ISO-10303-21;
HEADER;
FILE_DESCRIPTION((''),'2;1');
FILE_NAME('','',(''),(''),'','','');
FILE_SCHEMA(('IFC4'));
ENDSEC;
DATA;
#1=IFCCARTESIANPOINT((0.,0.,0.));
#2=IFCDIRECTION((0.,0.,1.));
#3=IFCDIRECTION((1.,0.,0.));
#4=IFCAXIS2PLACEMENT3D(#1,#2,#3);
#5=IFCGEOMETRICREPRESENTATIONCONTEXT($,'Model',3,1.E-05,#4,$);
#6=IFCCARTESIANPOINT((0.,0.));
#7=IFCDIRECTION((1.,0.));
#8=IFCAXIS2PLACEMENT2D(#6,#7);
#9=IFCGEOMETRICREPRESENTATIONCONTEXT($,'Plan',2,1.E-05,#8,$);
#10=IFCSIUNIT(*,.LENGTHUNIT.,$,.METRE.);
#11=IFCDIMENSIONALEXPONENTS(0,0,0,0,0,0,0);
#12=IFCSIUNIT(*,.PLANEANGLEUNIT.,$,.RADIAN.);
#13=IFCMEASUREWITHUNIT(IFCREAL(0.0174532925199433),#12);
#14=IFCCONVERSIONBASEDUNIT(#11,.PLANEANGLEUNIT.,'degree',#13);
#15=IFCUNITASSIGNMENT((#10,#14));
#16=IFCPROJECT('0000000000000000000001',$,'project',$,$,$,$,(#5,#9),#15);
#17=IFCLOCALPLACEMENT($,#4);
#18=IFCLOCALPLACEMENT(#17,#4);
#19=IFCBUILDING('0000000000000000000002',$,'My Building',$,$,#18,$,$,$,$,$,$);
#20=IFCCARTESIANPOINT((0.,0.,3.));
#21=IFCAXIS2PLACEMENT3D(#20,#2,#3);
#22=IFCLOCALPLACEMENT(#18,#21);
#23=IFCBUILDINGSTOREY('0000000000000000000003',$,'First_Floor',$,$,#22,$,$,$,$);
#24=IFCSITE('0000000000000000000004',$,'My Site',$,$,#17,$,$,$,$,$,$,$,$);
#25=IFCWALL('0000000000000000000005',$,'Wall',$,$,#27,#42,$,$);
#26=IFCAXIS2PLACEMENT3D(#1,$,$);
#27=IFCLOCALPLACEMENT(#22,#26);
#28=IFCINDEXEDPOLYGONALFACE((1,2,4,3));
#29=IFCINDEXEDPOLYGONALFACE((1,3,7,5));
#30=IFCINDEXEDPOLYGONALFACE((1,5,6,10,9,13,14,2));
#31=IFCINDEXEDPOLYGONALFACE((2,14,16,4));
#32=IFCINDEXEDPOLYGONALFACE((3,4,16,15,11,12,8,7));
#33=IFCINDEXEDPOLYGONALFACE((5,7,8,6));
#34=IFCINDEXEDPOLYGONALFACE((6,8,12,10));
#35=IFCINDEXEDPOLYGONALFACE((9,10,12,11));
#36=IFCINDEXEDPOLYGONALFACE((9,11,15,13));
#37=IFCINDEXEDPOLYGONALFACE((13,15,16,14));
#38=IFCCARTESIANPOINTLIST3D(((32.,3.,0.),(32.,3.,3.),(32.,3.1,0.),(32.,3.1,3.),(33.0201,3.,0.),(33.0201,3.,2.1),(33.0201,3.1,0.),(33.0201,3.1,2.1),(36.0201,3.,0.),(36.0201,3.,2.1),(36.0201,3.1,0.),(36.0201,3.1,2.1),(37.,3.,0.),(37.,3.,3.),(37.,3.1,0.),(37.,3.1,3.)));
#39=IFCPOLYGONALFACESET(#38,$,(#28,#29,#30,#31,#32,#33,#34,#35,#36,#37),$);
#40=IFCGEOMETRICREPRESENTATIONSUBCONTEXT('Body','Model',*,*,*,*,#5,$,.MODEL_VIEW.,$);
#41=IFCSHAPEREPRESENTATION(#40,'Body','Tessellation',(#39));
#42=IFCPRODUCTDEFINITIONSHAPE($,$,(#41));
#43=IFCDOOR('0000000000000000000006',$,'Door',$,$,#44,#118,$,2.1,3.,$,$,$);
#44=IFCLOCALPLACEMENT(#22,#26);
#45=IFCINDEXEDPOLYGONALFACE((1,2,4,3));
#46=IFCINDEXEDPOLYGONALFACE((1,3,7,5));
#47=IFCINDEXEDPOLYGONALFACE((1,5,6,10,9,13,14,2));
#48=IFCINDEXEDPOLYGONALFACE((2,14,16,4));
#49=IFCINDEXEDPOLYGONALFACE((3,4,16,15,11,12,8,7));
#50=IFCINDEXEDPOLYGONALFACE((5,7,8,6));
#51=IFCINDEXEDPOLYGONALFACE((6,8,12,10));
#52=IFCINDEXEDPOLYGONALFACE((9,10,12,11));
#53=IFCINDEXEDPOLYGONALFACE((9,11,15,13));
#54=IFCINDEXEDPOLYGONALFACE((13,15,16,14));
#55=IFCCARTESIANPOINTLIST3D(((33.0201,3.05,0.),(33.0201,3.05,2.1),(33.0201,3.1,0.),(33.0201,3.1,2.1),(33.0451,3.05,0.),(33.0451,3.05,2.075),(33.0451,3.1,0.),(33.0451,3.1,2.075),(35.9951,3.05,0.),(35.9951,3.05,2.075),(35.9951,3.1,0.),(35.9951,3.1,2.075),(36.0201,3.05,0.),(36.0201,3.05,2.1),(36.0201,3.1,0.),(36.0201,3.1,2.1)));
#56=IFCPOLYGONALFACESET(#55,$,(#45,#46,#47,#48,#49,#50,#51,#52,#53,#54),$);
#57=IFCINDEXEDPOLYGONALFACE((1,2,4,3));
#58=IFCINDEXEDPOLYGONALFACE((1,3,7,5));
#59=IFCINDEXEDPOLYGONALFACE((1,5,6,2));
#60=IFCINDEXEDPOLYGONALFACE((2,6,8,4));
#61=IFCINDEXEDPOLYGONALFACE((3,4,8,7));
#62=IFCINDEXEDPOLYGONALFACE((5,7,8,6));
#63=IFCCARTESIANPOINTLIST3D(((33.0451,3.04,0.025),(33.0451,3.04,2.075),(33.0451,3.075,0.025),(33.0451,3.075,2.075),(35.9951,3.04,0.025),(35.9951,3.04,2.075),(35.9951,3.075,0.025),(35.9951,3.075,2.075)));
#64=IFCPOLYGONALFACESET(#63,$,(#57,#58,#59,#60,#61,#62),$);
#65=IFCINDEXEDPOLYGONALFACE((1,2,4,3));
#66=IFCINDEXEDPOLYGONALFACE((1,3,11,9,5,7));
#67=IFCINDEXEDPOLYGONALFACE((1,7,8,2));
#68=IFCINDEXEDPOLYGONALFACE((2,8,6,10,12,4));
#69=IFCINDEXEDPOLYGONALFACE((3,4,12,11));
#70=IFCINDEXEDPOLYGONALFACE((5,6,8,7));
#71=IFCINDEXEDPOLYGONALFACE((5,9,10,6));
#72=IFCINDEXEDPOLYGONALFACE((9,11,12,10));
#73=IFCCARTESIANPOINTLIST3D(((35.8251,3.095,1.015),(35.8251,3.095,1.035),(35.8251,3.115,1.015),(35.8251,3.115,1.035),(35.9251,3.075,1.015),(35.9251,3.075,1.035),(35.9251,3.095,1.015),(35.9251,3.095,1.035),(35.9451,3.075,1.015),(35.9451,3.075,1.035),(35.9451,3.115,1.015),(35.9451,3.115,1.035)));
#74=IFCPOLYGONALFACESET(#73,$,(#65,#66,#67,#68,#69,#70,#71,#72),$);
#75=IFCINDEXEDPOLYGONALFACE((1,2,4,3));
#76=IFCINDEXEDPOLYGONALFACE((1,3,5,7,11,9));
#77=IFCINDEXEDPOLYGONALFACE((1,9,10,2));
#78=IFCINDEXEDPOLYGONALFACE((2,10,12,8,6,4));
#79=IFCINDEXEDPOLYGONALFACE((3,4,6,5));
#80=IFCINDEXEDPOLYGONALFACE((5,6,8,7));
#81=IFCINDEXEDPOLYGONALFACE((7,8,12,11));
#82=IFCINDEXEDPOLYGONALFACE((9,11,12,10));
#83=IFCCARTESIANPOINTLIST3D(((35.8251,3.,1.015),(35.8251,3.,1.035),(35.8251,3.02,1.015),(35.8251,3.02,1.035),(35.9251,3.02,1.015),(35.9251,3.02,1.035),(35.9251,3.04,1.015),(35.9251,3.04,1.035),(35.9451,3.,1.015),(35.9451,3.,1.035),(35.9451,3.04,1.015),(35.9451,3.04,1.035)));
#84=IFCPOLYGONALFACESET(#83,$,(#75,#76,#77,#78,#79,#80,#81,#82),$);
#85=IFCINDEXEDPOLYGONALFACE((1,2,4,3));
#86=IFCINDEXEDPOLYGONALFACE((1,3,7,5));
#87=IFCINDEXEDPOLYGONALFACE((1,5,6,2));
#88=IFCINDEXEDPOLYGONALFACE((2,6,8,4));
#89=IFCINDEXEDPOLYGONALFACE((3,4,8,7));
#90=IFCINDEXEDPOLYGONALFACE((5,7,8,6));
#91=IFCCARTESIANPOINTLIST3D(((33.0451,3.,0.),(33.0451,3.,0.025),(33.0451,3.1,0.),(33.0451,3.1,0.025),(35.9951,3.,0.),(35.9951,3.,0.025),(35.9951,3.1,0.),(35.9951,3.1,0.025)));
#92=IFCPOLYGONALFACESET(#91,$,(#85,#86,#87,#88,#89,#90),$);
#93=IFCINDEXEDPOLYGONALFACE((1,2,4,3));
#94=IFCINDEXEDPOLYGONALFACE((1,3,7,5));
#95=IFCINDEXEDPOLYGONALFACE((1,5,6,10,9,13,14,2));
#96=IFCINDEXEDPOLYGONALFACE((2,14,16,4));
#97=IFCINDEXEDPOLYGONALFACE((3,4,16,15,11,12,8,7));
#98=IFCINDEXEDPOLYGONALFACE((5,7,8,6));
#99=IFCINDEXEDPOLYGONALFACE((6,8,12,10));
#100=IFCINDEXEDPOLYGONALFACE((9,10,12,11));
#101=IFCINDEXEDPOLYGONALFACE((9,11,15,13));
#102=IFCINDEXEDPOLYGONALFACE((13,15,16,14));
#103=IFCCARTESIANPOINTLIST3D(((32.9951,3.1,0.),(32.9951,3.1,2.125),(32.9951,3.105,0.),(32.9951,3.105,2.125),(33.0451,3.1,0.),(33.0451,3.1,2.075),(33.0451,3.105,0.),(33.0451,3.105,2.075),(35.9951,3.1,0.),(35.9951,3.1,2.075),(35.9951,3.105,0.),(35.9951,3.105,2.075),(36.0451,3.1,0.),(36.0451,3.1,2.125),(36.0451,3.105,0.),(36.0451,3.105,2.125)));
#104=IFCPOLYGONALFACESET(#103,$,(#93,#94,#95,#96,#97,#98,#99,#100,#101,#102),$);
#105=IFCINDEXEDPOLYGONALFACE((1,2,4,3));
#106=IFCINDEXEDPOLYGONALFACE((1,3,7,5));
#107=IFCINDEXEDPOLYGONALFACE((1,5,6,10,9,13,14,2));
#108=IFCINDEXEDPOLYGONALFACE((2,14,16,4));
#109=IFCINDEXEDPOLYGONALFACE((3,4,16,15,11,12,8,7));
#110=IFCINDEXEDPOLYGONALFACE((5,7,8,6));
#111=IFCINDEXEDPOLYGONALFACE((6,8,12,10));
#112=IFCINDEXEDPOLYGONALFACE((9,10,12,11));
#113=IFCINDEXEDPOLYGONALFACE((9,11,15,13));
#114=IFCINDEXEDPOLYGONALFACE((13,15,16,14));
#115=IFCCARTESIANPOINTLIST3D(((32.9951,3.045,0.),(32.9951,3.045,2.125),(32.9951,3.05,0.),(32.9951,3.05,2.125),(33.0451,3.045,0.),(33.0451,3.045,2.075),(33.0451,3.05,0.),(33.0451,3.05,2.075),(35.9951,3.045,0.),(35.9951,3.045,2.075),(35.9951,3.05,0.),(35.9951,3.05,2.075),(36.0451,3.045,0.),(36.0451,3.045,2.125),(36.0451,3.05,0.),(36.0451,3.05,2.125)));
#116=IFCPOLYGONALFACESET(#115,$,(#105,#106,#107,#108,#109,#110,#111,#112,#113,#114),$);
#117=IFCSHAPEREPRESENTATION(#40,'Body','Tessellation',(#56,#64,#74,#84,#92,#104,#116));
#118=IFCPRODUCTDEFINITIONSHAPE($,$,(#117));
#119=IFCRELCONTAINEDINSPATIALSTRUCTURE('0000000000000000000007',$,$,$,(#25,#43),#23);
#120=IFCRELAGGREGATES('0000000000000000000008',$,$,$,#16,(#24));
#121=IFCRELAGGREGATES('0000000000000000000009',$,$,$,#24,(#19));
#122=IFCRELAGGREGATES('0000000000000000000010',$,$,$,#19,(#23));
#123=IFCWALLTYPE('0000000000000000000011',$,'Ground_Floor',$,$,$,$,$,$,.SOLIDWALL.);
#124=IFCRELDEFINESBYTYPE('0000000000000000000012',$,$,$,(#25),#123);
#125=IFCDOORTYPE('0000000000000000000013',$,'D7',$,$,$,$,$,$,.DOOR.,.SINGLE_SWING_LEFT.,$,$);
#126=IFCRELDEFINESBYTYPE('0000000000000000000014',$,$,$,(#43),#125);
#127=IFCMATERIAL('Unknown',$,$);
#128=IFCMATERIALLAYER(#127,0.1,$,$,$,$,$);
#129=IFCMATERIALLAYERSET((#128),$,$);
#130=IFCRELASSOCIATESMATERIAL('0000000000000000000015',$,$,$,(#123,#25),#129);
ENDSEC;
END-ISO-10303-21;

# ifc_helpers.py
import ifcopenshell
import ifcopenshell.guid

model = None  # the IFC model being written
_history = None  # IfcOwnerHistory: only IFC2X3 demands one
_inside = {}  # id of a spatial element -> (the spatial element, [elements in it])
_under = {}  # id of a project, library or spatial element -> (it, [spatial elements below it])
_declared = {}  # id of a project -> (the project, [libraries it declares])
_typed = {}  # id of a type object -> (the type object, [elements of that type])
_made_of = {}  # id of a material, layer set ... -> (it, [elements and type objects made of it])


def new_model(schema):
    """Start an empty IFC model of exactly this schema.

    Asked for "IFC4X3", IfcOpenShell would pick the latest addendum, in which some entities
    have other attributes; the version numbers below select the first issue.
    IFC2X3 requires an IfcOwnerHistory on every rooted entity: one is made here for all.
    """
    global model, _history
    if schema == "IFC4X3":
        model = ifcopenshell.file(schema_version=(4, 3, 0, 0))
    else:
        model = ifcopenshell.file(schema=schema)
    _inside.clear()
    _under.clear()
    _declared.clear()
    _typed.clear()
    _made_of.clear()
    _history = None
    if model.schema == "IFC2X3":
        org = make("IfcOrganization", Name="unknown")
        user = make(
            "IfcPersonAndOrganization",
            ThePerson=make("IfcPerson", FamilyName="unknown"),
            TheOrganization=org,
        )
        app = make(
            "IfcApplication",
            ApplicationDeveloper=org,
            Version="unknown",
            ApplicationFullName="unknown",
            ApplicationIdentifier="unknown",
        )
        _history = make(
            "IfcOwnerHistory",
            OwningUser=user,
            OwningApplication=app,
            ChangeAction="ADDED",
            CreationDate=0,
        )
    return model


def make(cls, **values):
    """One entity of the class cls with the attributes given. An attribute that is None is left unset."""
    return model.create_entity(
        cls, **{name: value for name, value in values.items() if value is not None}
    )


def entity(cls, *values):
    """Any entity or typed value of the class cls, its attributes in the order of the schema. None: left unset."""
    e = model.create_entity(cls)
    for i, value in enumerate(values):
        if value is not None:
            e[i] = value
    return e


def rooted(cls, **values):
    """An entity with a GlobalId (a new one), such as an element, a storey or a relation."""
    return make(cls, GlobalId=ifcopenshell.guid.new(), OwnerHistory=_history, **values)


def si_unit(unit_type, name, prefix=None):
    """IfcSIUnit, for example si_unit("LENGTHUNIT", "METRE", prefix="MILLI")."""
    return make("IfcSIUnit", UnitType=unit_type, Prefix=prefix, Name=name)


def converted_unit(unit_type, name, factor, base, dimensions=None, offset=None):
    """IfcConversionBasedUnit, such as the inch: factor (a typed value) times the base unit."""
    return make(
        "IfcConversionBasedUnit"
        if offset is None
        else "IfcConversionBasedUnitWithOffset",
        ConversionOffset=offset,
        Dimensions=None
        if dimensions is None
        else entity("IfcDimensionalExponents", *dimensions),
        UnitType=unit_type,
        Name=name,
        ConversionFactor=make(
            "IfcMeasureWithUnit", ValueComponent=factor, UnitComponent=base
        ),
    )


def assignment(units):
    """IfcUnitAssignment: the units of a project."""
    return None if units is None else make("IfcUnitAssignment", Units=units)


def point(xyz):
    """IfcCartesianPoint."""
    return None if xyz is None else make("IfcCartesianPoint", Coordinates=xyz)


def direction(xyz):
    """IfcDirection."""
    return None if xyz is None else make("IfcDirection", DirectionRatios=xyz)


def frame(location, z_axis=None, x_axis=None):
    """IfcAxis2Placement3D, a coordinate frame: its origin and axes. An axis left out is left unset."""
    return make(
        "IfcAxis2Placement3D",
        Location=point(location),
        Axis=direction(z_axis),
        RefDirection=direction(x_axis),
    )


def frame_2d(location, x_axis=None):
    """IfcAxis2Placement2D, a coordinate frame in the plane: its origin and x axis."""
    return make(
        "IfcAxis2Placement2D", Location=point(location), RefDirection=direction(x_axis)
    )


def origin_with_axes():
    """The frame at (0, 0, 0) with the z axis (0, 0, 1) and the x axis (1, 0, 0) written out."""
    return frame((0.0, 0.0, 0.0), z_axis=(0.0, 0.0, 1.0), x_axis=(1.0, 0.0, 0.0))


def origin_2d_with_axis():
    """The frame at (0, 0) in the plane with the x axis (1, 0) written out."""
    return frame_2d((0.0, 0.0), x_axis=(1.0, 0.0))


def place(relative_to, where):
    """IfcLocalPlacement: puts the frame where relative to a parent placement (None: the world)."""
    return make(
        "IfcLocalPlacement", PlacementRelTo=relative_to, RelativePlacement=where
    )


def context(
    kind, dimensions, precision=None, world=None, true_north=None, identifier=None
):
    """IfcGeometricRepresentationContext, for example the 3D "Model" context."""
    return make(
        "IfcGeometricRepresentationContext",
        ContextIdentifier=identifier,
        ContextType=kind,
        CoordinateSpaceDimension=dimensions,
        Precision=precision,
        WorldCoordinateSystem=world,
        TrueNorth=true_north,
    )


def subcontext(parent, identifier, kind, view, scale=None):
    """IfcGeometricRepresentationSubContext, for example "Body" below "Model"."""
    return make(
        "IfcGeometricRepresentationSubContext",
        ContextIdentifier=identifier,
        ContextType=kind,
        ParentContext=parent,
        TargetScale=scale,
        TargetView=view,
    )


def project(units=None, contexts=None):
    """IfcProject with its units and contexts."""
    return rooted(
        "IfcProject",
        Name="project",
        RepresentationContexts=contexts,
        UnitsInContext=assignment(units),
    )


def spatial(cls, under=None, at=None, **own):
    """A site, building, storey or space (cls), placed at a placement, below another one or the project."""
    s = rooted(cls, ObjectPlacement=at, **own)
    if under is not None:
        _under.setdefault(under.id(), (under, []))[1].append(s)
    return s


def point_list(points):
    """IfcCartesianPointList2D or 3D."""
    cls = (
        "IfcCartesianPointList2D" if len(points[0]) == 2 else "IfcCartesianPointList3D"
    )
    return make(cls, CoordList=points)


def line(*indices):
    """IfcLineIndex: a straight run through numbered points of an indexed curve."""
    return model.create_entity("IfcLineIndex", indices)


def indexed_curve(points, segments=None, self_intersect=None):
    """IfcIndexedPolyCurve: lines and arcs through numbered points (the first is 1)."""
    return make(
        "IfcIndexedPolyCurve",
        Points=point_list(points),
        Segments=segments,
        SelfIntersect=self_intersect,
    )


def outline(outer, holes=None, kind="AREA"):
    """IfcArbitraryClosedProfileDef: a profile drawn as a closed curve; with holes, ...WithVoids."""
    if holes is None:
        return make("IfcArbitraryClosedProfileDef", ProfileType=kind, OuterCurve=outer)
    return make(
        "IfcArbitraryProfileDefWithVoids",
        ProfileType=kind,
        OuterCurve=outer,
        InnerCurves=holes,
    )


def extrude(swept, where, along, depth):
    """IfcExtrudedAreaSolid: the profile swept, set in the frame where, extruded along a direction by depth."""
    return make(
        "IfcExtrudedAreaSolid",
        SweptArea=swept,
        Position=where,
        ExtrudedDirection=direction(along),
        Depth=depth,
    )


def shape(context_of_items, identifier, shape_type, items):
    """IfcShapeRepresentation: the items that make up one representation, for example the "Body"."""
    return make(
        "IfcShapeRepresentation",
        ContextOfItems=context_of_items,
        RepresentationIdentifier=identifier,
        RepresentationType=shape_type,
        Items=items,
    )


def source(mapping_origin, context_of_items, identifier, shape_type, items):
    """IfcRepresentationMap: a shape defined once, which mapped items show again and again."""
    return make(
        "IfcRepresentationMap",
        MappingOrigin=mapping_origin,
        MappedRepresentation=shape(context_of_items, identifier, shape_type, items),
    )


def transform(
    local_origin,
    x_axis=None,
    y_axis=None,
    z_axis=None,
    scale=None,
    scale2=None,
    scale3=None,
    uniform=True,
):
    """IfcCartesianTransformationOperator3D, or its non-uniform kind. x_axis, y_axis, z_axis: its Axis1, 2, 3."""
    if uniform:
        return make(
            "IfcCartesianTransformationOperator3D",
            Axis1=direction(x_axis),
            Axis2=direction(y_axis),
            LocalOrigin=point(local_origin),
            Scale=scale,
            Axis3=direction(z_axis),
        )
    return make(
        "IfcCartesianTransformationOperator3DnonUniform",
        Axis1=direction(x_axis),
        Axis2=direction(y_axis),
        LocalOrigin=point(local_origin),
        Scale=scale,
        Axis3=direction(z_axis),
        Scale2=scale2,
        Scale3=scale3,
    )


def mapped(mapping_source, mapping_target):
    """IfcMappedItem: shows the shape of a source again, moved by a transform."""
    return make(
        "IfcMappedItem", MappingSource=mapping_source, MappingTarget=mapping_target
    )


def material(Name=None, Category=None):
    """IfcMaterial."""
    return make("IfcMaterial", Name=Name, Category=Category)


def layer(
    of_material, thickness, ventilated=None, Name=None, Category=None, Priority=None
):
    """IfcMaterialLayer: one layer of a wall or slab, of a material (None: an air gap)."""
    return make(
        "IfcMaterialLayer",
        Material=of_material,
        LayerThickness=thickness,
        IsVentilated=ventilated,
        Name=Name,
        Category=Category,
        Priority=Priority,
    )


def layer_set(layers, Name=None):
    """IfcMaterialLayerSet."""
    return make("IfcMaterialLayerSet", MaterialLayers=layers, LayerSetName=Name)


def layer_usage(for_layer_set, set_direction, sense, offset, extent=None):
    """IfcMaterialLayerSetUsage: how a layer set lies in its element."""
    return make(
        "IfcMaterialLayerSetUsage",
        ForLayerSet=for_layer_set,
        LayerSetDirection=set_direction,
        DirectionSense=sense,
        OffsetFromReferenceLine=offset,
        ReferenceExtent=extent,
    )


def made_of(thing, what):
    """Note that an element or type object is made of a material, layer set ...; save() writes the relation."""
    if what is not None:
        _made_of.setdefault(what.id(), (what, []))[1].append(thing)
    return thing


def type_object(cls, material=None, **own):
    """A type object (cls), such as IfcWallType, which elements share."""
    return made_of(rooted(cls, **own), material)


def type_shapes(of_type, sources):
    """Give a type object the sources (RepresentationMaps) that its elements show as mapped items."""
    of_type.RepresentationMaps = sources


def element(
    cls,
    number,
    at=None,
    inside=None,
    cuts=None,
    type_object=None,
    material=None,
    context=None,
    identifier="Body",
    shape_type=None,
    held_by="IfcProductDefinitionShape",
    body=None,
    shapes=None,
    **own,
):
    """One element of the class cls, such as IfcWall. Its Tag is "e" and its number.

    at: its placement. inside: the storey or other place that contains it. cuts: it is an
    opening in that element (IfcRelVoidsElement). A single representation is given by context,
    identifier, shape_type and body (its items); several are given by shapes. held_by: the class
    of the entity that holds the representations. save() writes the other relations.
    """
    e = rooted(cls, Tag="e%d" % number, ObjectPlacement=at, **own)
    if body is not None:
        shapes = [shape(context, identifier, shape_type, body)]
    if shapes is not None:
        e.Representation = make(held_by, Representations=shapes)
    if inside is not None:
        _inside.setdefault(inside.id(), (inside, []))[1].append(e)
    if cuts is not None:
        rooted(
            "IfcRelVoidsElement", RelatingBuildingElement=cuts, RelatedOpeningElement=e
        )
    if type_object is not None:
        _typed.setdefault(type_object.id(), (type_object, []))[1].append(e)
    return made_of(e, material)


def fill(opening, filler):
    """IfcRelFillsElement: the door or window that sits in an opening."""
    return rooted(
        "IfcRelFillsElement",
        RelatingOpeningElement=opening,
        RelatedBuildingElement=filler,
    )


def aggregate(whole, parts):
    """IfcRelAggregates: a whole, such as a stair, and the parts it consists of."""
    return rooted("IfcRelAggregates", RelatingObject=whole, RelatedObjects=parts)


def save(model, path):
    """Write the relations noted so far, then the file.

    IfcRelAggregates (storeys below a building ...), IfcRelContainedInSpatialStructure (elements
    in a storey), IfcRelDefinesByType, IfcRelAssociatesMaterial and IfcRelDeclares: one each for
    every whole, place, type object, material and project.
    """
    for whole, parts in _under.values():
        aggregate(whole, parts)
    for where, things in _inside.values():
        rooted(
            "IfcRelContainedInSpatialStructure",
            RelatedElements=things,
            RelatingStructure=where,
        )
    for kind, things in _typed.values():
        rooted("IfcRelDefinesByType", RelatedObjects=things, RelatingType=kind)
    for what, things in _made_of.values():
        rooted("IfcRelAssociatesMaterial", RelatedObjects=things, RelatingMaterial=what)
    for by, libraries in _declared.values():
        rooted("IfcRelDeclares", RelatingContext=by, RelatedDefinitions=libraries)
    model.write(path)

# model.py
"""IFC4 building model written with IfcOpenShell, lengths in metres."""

from ifc_helpers import new_model, entity, si_unit, converted_unit, frame, origin_with_axes, origin_2d_with_axis, place, context, subcontext, project, spatial, line, indexed_curve, outline, extrude, shape, source, transform, mapped, material, layer, layer_set, layer_usage, type_object, type_shapes, element, fill, save


model = new_model("IFC4")

# Units and contexts
model_context = context("Model", 3, precision=1e-05, world=origin_with_axes())
plan_context = context("Plan", 2, precision=1e-05, world=origin_2d_with_axis())
body_context_1 = subcontext(model_context, "Body", "Model", "MODEL_VIEW")
body_context_2 = subcontext(plan_context, "Body", "Plan", "PLAN_VIEW")
ifc_project = project(units=[si_unit("LENGTHUNIT", "METRE"), converted_unit("PLANEANGLEUNIT", "degree", entity("IfcReal", 0.0174532925199433), si_unit("PLANEANGLEUNIT", "RADIAN"), dimensions=[0, 0, 0, 0, 0, 0, 0])], contexts=[model_context, plan_context])

# Site, building, storey
site_placement = place(None, origin_with_axes())
site = spatial("IfcSite", under=ifc_project, at=site_placement, Name="My Site")
building_placement = place(site_placement, origin_with_axes())
building = spatial("IfcBuilding", under=site, at=building_placement, Name="My Building")
storey_placement = place(building_placement, frame((0.0, 0.0, 3.0), z_axis=(0.0, 0.0, 1.0), x_axis=(1.0, 0.0, 0.0)))
storey = spatial("IfcBuildingStorey", under=building, at=storey_placement, Name="First_Floor")

# Shared definitions
ifc_material = material(Name="Unknown")

# Shared definitions
ifc_layer = layer(ifc_material, 0.1)
ifc_layer_set = layer_set([ifc_layer])
wall_type = type_object("IfcWallType", Name="Ground_Floor", PredefinedType="SOLIDWALL", material=ifc_layer_set)

# Wall, opening, door
ifc_layer_usage_1 = layer_usage(ifc_layer_set, "AXIS2", "POSITIVE", 0.0)
wall_1_placement = place(storey_placement, frame((32.0, 3.0, 0.0), z_axis=(0.0, 0.0, 1.0), x_axis=(1.0, 0.0, 0.0)))
wall_1 = element("IfcWall", 1, at=wall_1_placement, inside=storey, type_object=wall_type, material=ifc_layer_usage_1, Name="Wall", context=body_context_1, shape_type="SweptSolid", body=[
    extrude(outline(indexed_curve([(0.0, 0.0), (0.0, 0.1), (5.0, 0.1), (5.0, 0.0)], segments=[line(1, 2, 3, 4, 1)])), origin_with_axes(), (0.0, 0.0, 1.0), 3.0),
])
shared_shape_1 = source(origin_with_axes(), body_context_1, "Body", "SweptSolid", [
    extrude(outline(indexed_curve([(0.0, 0.0), (3.0, 0.0), (3.0, 2.1), (0.0, 2.1)], segments=[line(1, 2, 3, 4, 1)])), frame((0.0, -0.6, 0.0), z_axis=(0.0, -1.0, 0.0), x_axis=(1.0, 0.0, 0.0)), (0.0, 0.0, -1.0), 1.2),
])
opening_1_placement = place(wall_1_placement, frame((4.0201, 0.1, 0.0), z_axis=(0.0, 0.0, 1.0), x_axis=(-1.0, 0.0, 0.0)))
opening_1 = element("IfcOpeningElement", 2, at=opening_1_placement, cuts=wall_1, PredefinedType="OPENING", context=body_context_1, shape_type="MappedRepresentation", body=[
    mapped(shared_shape_1, transform((0.0, 0.0, 0.0), x_axis=(1.0, 0.0, 0.0), y_axis=(0.0, 1.0, 0.0), z_axis=(0.0, 0.0, 1.0), scale=1.0)),
])
door_type_1 = type_object("IfcDoorType", Name="D7", OperationType="SINGLE_SWING_LEFT", PredefinedType="DOOR")
shared_shape_2 = source(origin_with_axes(), body_context_1, "Body", "SweptSolid", [
    extrude(outline(indexed_curve([(0.0, 0.0), (0.0, 2.1), (3.0, 2.1), (3.0, 0.0), (2.975, 0.0), (2.975, 2.075), (0.025, 2.075), (0.025, 0.0)], segments=[line(1, 2, 3, 4, 5, 6, 7, 8, 1)])), frame((0.0, 0.0, 0.0), z_axis=(0.0, -1.0, 0.0), x_axis=(1.0, 0.0, 0.0)), (0.0, 0.0, -1.0), 0.05),
    extrude(outline(indexed_curve([(0.0, 0.0), (2.95, 0.0), (2.95, 0.035), (0.0, 0.035)], segments=[line(1, 2, 3, 4, 1)])), frame((0.025, 0.025, 0.025), z_axis=(0.0, 0.0, 1.0), x_axis=(1.0, 0.0, 0.0)), (0.0, 0.0, 1.0), 2.05),
    extrude(outline(indexed_curve([(0.0, 0.0), (0.0, -0.04), (0.12, -0.04), (0.12, -0.02), (0.02, -0.02), (0.02, 0.0)], segments=[line(1, 2, 3, 4, 5, 6, 1)])), frame((0.075, 0.025, 1.015), z_axis=(0.0, 0.0, 1.0), x_axis=(1.0, 0.0, 0.0)), (0.0, 0.0, 1.0), 0.02),
    extrude(outline(indexed_curve([(0.0, 0.0), (0.0, 0.04), (0.12, 0.04), (0.12, 0.02), (0.02, 0.02), (0.02, 0.0)], segments=[line(1, 2, 3, 4, 5, 6, 1)])), frame((0.075, 0.06, 1.015), z_axis=(0.0, 0.0, 1.0), x_axis=(1.0, 0.0, 0.0)), (0.0, 0.0, 1.0), 0.02),
    extrude(outline(indexed_curve([(0.0, 0.0), (2.95, 0.0), (2.95, 0.1), (0.0, 0.1)], segments=[line(1, 2, 3, 4, 1)])), frame((0.025, 0.0, 0.0), z_axis=(0.0, 0.0, 1.0), x_axis=(1.0, 0.0, 0.0)), (0.0, 0.0, 1.0), 0.025),
    extrude(outline(indexed_curve([(0.0, 0.0), (0.0, 2.125), (3.05, 2.125), (3.05, 0.0), (3.0, 0.0), (3.0, 2.075), (0.05, 2.075), (0.05, 0.0)], segments=[line(1, 2, 3, 4, 5, 6, 7, 8, 1)])), frame((-0.025, -0.005, 0.0), z_axis=(0.0, -1.0, 0.0), x_axis=(1.0, 0.0, 0.0)), (0.0, 0.0, -1.0), 0.005),
    extrude(outline(indexed_curve([(0.0, 0.0), (0.0, 2.125), (3.05, 2.125), (3.05, 0.0), (3.0, 0.0), (3.0, 2.075), (0.05, 2.075), (0.05, 0.0)], segments=[line(1, 2, 3, 4, 5, 6, 7, 8, 1)])), frame((-0.025, 0.05, 0.0), z_axis=(0.0, -1.0, 0.0), x_axis=(1.0, 0.0, 0.0)), (0.0, 0.0, -1.0), 0.005),
])
shared_shape_3 = source(origin_with_axes(), body_context_2, "Body", "Curve2D", [
    entity("IfcIndexedPolyCurve", entity("IfcCartesianPointList2D", [[0.0, 0.0], [0.025, 0.0], [0.025, 0.05], [0.0, 0.05]]), [entity("IfcLineIndex", [1, 2, 3, 4, 1])]),
    entity("IfcIndexedPolyCurve", entity("IfcCartesianPointList2D", [[3.0, 0.0], [2.975, 0.0], [2.975, 0.05], [3.0, 0.05]]), [entity("IfcLineIndex", [1, 2, 3, 4, 1])]),
    entity("IfcIndexedPolyCurve", entity("IfcCartesianPointList2D", [[2.975, 0.05], [2.975, -2.9], [2.94, -2.9]])),
    entity("IfcTrimmedCurve", entity("IfcEllipse", entity("IfcAxis2Placement2D", entity("IfcCartesianPoint", [2.94, 0.05]), entity("IfcDirection", [1.0, 0.0])), 2.915, 2.95), [entity("IfcCartesianPoint", [2.94, 3.0])], [entity("IfcCartesianPoint", [2.94, -2.9])], True, "CARTESIAN"),
    entity("IfcIndexedPolyCurve", entity("IfcCartesianPointList2D", [[2.975, 0.05], [2.94, 0.05], [2.94, 3.0], [2.975, 3.0]]), [entity("IfcLineIndex", [1, 2, 3, 4, 1])]),
])
type_shapes(door_type_1, [shared_shape_2, shared_shape_3])
door_1_placement = place(opening_1_placement, frame((0.0, 0.0, 0.0), z_axis=(0.0, 0.0, 1.0), x_axis=(1.0, 0.0, 0.0)))
door_1 = element("IfcDoor", 3, at=door_1_placement, inside=storey, type_object=door_type_1, Name="Door", OverallHeight=2.1, OverallWidth=3.0, shapes=[
    shape(body_context_1, "Body", "MappedRepresentation", [mapped(shared_shape_2, transform((0.0, 0.0, 0.0), x_axis=(1.0, 0.0, 0.0), y_axis=(0.0, 1.0, 0.0), z_axis=(0.0, 0.0, 1.0), scale=1.0))]),
    shape(body_context_2, "Body", "MappedRepresentation", [mapped(shared_shape_3, transform((0.0, 0.0, 0.0), x_axis=(1.0, 0.0, 0.0), y_axis=(0.0, 1.0, 0.0), z_axis=(0.0, 0.0, 1.0), scale=1.0))]),
])
fill(opening_1, door_1)

save(model, "model.ifc")
